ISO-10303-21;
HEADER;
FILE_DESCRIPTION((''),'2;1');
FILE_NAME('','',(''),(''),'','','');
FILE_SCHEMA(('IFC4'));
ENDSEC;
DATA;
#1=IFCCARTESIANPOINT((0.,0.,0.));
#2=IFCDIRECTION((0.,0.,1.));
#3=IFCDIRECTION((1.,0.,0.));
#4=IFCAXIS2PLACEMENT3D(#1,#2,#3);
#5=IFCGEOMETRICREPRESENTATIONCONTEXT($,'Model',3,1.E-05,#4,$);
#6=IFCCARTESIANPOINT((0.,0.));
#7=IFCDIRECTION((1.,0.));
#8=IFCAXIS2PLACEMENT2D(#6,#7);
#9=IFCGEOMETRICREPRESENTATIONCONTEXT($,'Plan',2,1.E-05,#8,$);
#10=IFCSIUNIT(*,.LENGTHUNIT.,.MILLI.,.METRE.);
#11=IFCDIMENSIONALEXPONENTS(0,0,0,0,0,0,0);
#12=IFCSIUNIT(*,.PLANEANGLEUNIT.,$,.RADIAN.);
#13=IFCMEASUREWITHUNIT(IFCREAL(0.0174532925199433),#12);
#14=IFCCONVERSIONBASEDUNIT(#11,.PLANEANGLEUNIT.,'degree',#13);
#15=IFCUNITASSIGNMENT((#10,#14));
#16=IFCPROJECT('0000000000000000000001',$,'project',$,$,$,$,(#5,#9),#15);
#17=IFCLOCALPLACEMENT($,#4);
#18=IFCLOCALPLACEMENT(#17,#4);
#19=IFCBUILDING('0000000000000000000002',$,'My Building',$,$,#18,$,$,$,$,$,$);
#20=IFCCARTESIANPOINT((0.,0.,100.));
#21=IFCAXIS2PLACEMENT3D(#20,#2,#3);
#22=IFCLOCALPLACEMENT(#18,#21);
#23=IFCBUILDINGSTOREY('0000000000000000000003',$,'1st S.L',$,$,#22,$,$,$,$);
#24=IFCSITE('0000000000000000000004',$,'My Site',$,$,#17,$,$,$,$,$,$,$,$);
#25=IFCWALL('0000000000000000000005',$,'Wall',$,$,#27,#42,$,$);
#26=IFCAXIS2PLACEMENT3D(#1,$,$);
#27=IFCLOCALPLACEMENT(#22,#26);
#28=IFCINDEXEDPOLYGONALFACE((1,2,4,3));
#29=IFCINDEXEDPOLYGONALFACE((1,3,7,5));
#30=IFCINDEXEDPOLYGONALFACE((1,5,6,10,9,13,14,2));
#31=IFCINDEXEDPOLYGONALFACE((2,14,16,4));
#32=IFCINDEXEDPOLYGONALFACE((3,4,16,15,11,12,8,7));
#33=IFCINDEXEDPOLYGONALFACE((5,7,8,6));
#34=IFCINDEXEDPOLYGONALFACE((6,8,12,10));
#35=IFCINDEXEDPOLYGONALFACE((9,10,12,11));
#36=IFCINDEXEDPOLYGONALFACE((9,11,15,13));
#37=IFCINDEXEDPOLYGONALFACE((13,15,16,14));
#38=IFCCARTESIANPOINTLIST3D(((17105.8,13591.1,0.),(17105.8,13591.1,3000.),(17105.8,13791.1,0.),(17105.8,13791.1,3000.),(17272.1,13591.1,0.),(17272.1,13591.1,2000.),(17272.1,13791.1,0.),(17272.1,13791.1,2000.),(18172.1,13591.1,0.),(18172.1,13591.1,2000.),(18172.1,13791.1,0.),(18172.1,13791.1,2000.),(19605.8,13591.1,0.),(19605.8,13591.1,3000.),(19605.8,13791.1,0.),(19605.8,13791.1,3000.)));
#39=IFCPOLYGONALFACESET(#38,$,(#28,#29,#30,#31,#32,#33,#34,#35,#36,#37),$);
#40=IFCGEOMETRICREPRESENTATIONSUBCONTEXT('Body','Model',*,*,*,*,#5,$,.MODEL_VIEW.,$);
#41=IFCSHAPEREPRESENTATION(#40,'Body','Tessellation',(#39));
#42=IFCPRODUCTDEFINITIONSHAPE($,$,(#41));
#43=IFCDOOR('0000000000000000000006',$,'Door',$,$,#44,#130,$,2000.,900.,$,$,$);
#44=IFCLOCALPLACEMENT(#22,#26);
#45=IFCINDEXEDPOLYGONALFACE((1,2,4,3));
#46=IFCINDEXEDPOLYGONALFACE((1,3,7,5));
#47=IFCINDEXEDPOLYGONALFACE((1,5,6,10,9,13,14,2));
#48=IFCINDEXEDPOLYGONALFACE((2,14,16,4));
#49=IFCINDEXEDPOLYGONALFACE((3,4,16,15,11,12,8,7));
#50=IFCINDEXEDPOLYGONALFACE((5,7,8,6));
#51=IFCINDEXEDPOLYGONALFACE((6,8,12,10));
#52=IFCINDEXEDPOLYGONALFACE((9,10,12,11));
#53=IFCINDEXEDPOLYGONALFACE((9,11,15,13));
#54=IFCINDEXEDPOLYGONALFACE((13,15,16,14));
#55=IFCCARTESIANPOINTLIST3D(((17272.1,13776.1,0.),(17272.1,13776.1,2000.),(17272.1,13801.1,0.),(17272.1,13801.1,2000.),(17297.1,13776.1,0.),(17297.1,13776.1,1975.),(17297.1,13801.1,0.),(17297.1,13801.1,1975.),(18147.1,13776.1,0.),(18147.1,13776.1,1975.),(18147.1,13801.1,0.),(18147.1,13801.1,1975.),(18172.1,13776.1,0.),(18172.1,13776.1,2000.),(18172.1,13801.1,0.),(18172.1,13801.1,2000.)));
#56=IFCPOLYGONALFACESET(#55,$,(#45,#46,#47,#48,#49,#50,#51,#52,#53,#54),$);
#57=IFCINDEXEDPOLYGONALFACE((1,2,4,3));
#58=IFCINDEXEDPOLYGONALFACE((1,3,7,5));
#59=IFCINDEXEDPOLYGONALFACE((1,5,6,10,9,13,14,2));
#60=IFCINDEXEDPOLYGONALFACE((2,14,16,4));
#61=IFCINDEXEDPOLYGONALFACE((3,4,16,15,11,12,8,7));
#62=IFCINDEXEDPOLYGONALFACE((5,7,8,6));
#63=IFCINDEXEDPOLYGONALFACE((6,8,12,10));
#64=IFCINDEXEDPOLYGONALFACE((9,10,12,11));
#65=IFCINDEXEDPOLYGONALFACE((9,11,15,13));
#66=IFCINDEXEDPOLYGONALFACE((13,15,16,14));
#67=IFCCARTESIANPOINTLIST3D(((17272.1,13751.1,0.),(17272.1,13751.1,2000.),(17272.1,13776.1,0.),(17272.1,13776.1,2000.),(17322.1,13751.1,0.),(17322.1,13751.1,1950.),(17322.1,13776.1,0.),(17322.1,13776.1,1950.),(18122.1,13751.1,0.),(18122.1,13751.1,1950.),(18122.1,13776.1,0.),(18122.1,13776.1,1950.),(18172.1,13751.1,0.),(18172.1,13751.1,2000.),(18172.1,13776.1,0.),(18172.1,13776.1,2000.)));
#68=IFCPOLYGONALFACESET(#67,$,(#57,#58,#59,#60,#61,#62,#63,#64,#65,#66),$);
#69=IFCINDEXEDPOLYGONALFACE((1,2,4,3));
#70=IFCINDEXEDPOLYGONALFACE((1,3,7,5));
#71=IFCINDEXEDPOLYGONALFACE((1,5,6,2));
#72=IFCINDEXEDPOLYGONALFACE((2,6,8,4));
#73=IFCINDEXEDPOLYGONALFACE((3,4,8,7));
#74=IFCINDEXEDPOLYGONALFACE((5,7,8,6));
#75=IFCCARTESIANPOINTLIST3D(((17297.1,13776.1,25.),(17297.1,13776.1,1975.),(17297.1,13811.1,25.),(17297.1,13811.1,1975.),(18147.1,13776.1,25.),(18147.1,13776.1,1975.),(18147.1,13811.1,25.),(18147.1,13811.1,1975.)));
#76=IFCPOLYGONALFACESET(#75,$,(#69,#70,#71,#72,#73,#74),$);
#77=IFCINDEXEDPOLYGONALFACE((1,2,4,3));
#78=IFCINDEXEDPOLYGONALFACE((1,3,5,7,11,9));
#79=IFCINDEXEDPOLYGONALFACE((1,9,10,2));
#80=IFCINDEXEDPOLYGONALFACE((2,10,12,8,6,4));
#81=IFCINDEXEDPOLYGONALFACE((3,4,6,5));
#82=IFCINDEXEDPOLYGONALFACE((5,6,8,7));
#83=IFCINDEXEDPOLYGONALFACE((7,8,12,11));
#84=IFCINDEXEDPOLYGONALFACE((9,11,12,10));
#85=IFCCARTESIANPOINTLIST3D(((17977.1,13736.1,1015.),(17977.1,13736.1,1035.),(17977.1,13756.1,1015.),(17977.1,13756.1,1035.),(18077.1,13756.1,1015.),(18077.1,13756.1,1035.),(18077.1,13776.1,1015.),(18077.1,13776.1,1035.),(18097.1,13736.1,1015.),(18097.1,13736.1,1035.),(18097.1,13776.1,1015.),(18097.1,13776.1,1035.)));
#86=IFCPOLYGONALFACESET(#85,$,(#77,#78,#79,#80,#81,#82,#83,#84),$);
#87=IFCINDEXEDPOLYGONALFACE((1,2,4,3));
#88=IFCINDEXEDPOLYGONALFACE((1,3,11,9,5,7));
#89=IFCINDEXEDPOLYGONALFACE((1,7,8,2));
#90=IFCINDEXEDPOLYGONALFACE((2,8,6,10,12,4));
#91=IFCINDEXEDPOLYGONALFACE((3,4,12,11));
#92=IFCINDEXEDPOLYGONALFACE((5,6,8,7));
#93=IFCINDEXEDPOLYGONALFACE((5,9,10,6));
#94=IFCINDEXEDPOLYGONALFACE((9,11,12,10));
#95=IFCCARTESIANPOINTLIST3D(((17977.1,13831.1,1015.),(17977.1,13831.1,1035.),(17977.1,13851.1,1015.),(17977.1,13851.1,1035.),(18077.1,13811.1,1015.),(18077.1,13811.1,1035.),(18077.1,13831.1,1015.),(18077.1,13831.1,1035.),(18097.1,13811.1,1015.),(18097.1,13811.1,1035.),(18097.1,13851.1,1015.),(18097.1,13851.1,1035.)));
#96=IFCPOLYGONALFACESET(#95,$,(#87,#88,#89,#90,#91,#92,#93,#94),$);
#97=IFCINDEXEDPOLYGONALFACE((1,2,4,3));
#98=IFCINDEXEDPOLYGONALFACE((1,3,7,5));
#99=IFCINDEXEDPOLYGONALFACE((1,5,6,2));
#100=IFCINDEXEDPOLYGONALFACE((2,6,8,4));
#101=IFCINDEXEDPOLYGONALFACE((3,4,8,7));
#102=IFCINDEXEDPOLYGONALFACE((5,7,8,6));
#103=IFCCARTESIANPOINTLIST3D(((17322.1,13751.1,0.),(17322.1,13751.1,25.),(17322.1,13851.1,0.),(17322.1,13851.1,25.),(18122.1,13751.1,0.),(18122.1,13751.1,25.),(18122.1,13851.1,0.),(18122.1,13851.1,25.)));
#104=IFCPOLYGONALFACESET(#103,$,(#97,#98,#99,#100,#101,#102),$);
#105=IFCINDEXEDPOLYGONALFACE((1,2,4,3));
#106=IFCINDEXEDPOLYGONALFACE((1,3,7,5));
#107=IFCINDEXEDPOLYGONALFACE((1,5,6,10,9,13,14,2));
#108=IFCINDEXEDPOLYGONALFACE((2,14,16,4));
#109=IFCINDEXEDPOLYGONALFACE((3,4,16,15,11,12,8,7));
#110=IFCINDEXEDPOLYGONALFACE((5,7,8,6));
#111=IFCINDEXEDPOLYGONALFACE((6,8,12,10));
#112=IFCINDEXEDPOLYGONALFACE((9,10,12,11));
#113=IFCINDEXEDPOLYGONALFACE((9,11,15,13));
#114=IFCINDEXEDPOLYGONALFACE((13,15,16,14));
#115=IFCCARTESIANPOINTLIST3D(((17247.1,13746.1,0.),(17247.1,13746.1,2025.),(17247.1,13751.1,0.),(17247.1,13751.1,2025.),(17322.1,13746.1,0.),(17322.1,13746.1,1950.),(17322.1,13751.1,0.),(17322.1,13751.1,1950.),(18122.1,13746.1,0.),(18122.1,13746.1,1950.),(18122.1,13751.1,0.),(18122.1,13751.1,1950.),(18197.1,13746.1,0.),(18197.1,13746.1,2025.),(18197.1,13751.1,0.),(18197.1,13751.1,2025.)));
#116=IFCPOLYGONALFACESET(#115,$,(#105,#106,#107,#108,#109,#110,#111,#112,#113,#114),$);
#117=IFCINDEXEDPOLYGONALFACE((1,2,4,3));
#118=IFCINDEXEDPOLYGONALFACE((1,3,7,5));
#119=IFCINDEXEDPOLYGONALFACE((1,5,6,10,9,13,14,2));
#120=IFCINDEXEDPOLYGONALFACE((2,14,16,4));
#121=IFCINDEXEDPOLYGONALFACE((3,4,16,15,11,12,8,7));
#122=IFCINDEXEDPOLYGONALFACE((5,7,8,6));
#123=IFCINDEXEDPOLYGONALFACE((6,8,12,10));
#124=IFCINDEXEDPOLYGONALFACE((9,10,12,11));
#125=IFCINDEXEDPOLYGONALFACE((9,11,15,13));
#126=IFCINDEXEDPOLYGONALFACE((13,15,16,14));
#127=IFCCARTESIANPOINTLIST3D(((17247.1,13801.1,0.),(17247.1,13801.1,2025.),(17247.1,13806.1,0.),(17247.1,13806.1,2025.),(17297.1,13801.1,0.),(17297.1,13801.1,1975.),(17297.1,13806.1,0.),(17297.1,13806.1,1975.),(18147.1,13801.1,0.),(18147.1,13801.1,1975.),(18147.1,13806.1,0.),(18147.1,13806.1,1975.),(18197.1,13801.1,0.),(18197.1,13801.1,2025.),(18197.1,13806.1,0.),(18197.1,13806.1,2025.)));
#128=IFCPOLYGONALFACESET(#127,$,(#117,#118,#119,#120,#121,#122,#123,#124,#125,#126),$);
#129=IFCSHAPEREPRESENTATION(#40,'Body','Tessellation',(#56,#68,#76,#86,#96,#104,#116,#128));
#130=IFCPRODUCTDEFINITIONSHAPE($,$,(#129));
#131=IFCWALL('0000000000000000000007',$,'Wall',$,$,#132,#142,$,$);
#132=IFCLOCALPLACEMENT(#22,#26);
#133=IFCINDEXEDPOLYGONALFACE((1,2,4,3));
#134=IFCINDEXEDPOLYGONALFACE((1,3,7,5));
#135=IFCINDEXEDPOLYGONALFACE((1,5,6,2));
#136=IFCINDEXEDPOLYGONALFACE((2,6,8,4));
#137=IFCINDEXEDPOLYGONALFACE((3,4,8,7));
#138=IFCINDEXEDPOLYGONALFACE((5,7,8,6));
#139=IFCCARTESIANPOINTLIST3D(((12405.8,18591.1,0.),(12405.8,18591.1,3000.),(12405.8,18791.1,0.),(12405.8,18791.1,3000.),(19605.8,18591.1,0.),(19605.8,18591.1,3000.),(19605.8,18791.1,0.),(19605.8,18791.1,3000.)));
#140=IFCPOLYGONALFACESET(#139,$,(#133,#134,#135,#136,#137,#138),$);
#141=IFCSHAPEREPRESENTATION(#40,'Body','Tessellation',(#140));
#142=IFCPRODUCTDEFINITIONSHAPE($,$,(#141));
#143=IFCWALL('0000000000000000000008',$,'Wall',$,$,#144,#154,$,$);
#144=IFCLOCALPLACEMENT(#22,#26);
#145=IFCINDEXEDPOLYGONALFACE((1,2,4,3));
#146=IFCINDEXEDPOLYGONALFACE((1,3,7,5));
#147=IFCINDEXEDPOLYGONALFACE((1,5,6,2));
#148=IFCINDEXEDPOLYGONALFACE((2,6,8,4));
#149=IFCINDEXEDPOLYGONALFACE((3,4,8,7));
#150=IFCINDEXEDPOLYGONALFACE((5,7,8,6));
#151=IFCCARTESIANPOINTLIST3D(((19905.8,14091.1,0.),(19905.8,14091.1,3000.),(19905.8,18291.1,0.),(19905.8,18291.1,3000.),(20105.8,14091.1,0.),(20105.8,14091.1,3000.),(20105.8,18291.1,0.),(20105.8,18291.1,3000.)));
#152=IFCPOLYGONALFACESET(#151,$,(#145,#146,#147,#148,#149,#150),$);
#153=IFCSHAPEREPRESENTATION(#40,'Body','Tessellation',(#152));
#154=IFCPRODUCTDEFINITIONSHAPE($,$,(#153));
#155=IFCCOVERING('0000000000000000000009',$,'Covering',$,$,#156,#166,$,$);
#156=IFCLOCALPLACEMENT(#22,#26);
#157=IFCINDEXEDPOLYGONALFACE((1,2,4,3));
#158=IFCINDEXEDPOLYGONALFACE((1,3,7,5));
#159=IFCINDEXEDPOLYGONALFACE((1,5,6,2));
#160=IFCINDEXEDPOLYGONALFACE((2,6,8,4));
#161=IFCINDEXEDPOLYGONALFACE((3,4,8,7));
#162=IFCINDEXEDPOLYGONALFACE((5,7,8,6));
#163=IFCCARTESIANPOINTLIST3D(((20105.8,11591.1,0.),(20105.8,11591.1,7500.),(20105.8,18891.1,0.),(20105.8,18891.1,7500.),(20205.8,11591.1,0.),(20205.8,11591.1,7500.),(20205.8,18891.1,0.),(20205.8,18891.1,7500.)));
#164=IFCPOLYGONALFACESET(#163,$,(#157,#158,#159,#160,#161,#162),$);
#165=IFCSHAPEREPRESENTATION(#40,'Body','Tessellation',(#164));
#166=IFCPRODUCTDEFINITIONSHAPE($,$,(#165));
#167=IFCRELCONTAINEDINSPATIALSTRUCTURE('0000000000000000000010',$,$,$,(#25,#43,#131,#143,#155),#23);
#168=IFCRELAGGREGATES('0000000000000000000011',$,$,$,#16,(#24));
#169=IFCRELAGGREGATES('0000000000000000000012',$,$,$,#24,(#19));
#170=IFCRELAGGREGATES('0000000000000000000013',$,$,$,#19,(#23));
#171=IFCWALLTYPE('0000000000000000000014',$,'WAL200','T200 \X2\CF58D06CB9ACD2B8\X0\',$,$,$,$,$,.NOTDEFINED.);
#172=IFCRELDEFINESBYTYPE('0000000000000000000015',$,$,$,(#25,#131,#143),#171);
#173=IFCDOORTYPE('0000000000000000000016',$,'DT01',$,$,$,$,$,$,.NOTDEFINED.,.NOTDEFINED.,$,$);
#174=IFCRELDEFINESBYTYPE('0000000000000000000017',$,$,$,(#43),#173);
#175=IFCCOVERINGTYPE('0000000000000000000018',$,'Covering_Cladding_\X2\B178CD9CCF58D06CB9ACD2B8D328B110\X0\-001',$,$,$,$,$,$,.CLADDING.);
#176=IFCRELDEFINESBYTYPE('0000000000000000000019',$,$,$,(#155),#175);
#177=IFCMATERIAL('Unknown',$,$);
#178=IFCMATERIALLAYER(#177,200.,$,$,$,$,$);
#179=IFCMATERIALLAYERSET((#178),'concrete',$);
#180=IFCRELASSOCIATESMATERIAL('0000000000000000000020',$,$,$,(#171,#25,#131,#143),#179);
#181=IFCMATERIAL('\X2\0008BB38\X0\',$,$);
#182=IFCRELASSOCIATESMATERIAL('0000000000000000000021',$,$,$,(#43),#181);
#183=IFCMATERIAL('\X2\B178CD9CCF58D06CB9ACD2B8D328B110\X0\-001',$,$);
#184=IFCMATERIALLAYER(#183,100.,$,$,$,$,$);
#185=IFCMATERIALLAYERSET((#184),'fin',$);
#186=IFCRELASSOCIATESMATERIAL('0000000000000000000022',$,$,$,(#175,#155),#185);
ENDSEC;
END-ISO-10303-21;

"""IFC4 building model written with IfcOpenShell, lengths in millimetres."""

from ifc_helpers import new_model, entity, si_unit, converted_unit, frame, origin_with_axes, origin_2d_with_axis, place, context, subcontext, project, spatial, line, indexed_curve, outline, extrude, shape, source, transform, mapped, material, layer, layer_set, layer_usage, type_object, type_shapes, element, fill, save


model = new_model("IFC4")

# Units and contexts
model_context = context("Model", 3, precision=1e-05, world=origin_with_axes())
plan_context = context("Plan", 2, precision=1e-05, world=origin_2d_with_axis())
body_context_1 = subcontext(model_context, "Body", "Model", "MODEL_VIEW")
body_context_2 = subcontext(plan_context, "Body", "Plan", "PLAN_VIEW")
ifc_project = project(units=[si_unit("LENGTHUNIT", "METRE", prefix="MILLI"), converted_unit("PLANEANGLEUNIT", "degree", entity("IfcReal", 0.0174532925199433), si_unit("PLANEANGLEUNIT", "RADIAN"), dimensions=[0, 0, 0, 0, 0, 0, 0])], contexts=[model_context, plan_context])

# Site, building, storey
site_placement = place(None, origin_with_axes())
site = spatial("IfcSite", under=ifc_project, at=site_placement, Name="My Site")
building_placement = place(site_placement, origin_with_axes())
building = spatial("IfcBuilding", under=site, at=building_placement, Name="My Building")
storey_placement = place(building_placement, frame((0.0, 0.0, 100.0), z_axis=(0.0, 0.0, 1.0), x_axis=(1.0, 0.0, 0.0)))
storey = spatial("IfcBuildingStorey", under=building, at=storey_placement, Name="1st S.L")

# Shared definitions
ifc_material_1 = material(Name="Unknown")

# Shared definitions
ifc_layer_1 = layer(ifc_material_1, 200.0)
ifc_layer_set_1 = layer_set([ifc_layer_1], Name="concrete")
wall_type = type_object("IfcWallType", Name="WAL200", Description="T200 콘크리트", PredefinedType="NOTDEFINED", material=ifc_layer_set_1)

# Wall, opening, door
ifc_layer_usage_1 = layer_usage(ifc_layer_set_1, "AXIS2", "POSITIVE", 0.0)
wall_1_placement = place(storey_placement, frame((17105.8, 13591.1, 0.0), z_axis=(0.0, 0.0, 1.0), x_axis=(1.0, 0.0, 0.0)))
wall_1 = element("IfcWall", 1, at=wall_1_placement, inside=storey, type_object=wall_type, material=ifc_layer_usage_1, Name="Wall", context=body_context_1, shape_type="SweptSolid", body=[
    extrude(outline(indexed_curve([(0.0, 0.0), (0.0, 200.0), (2500.0, 200.0), (2500.0, 0.0), (0.0, 0.0)], self_intersect=False)), origin_with_axes(), (0.0, 0.0, 1.0), 3000.0),
])
shared_shape_1 = source(origin_with_axes(), body_context_1, "Body", "SolidModel", [
    extrude(outline(indexed_curve([(0.0, 0.0), (900.0, 0.0), (900.0, 2000.0), (0.0, 2000.0)], segments=[line(1, 2, 3, 4, 1)])), frame((0.0, -600.0, 0.0), z_axis=(0.0, -1.0, 0.0), x_axis=(1.0, 0.0, 0.0)), (0.0, 0.0, -1.0), 1200.0),
])
opening_placement = place(wall_1_placement, frame((166.3, 0.0, 0.0), z_axis=(0.0, 0.0, 1.0), x_axis=(1.0, 0.0, 0.0)))
opening = element("IfcOpeningElement", 2, at=opening_placement, cuts=wall_1, PredefinedType="OPENING", context=body_context_1, shape_type="MappedRepresentation", body=[
    mapped(shared_shape_1, transform((0.0, 0.0, 0.0), x_axis=(1.0, 0.0, 0.0), y_axis=(0.0, 1.0, 0.0), z_axis=(0.0, 0.0, 1.0), scale=1.0)),
])
ifc_material_2 = material(Name="\b문")
door_type = type_object("IfcDoorType", Name="DT01", OperationType="NOTDEFINED", PredefinedType="NOTDEFINED")
shared_shape_2 = source(origin_with_axes(), body_context_1, "Body", "SolidModel", [
    extrude(outline(indexed_curve([(0.0, 0.0), (0.0, 2000.0), (900.0, 2000.0), (900.0, 0.0), (875.0, 0.0), (875.0, 1975.0), (25.0, 1975.0), (25.0, 0.0)], segments=[line(1, 2, 3, 4, 5, 6, 7, 8, 1)])), frame((0.0, 25.0, 0.0), z_axis=(0.0, -1.0, 0.0), x_axis=(1.0, 0.0, 0.0)), (0.0, 0.0, -1.0), 25.0),
    extrude(outline(indexed_curve([(0.0, 0.0), (0.0, 2000.0), (900.0, 2000.0), (900.0, 0.0), (850.0, 0.0), (850.0, 1950.0), (50.0, 1950.0), (50.0, 0.0)], segments=[line(1, 2, 3, 4, 5, 6, 7, 8, 1)])), frame((0.0, 0.0, 0.0), z_axis=(0.0, -1.0, 0.0), x_axis=(1.0, 0.0, 0.0)), (0.0, 0.0, -1.0), 25.0),
    extrude(outline(indexed_curve([(0.0, 0.0), (850.0, 0.0), (850.0, 35.0), (0.0, 35.0)], segments=[line(1, 2, 3, 4, 1)])), frame((25.0, 25.0, 25.0), z_axis=(0.0, 0.0, 1.0), x_axis=(1.0, 0.0, 0.0)), (0.0, 0.0, 1.0), 1950.0),
    extrude(outline(indexed_curve([(0.0, 0.0), (0.0, -40.0), (-120.0, -40.0), (-120.0, -20.0), (-20.0, -20.0), (-20.0, 0.0)], segments=[line(1, 2, 3, 4, 5, 6, 1)])), frame((825.0, 25.0, 1015.0), z_axis=(0.0, 0.0, 1.0), x_axis=(1.0, 0.0, 0.0)), (0.0, 0.0, 1.0), 20.0),
    extrude(outline(indexed_curve([(0.0, 0.0), (0.0, 40.0), (-120.0, 40.0), (-120.0, 20.0), (-20.0, 20.0), (-20.0, 0.0)], segments=[line(1, 2, 3, 4, 5, 6, 1)])), frame((825.0, 60.0, 1015.0), z_axis=(0.0, 0.0, 1.0), x_axis=(1.0, 0.0, 0.0)), (0.0, 0.0, 1.0), 20.0),
    extrude(outline(indexed_curve([(0.0, 0.0), (800.0, 0.0), (800.0, 100.0), (0.0, 100.0)], segments=[line(1, 2, 3, 4, 1)])), frame((50.0, 0.0, 0.0), z_axis=(0.0, 0.0, 1.0), x_axis=(1.0, 0.0, 0.0)), (0.0, 0.0, 1.0), 25.0),
    extrude(outline(indexed_curve([(0.0, 0.0), (0.0, 2025.0), (950.0, 2025.0), (950.0, 0.0), (875.0, 0.0), (875.0, 1950.0), (75.0, 1950.0), (75.0, 0.0)], segments=[line(1, 2, 3, 4, 5, 6, 7, 8, 1)])), frame((-25.0, -5.0, 0.0), z_axis=(0.0, -1.0, 0.0), x_axis=(1.0, 0.0, 0.0)), (0.0, 0.0, -1.0), 5.0),
    extrude(outline(indexed_curve([(0.0, 0.0), (0.0, 2025.0), (950.0, 2025.0), (950.0, 0.0), (900.0, 0.0), (900.0, 1975.0), (50.0, 1975.0), (50.0, 0.0)], segments=[line(1, 2, 3, 4, 5, 6, 7, 8, 1)])), frame((-25.0, 50.0, 0.0), z_axis=(0.0, -1.0, 0.0), x_axis=(1.0, 0.0, 0.0)), (0.0, 0.0, -1.0), 5.0),
])
shared_shape_3 = source(origin_with_axes(), body_context_2, "Body", "Curve2D", [
    entity("IfcIndexedPolyCurve", entity("IfcCartesianPointList2D", [[0.0, 0.0], [0.0, 50.0], [25.0, 50.0], [25.0, 25.0], [50.0, 25.0], [50.0, 0.0]]), [entity("IfcLineIndex", [1, 2, 3, 4, 5, 6, 1])]),
    entity("IfcIndexedPolyCurve", entity("IfcCartesianPointList2D", [[900.0, 0.0], [900.0, 50.0], [875.0, 50.0], [875.0, 25.0], [850.0, 25.0], [850.0, 0.0]]), [entity("IfcLineIndex", [1, 2, 3, 4, 5, 6, 1])]),
    entity("IfcTrimmedCurve", entity("IfcEllipse", entity("IfcAxis2Placement2D", entity("IfcCartesianPoint", [60.0, 50.0]), entity("IfcDirection", [1.0, 0.0])), 815.0, 850.0), [entity("IfcCartesianPoint", [875.0, 50.0])], [entity("IfcCartesianPoint", [60.0, 900.0])], True, "CARTESIAN"),
    entity("IfcIndexedPolyCurve", entity("IfcCartesianPointList2D", [[25.0, 50.0], [60.0, 50.0], [60.0, 900.0], [25.0, 900.0]]), [entity("IfcLineIndex", [1, 2, 3, 4, 1])]),
])
type_shapes(door_type, [shared_shape_2, shared_shape_3])
door_placement = place(opening_placement, frame((0.0, 160.0, 0.0), z_axis=(0.0, 0.0, 1.0), x_axis=(1.0, 0.0, 0.0)))
door = element("IfcDoor", 3, at=door_placement, inside=storey, type_object=door_type, material=ifc_material_2, Name="Door", OverallHeight=2000.0, OverallWidth=900.0, shapes=[
    shape(body_context_1, "Body", "MappedRepresentation", [mapped(shared_shape_2, transform((0.0, 0.0, 0.0), x_axis=(1.0, 0.0, 0.0), y_axis=(0.0, 1.0, 0.0), z_axis=(0.0, 0.0, 1.0), scale=1.0))]),
    shape(body_context_2, "Body", "MappedRepresentation", [mapped(shared_shape_3, transform((0.0, 0.0, 0.0), x_axis=(1.0, 0.0, 0.0), y_axis=(0.0, 1.0, 0.0), z_axis=(0.0, 0.0, 1.0), scale=1.0))]),
])
fill(opening, door)

# Walls
ifc_layer_usage_2 = layer_usage(ifc_layer_set_1, "AXIS2", "POSITIVE", 0.0)
wall_2_placement = place(storey_placement, frame((12405.8, 18591.1, 0.0), z_axis=(0.0, 0.0, 1.0), x_axis=(1.0, 0.0, 0.0)))
element("IfcWall", 4, at=wall_2_placement, inside=storey, type_object=wall_type, material=ifc_layer_usage_2, Name="Wall", context=body_context_1, shape_type="SweptSolid", body=[
    extrude(outline(indexed_curve([(0.0, 0.0), (0.0, 200.0), (7200.0, 200.0), (7200.0, 0.0), (0.0, 0.0)], self_intersect=False)), origin_with_axes(), (0.0, 0.0, 1.0), 3000.0),
])
ifc_layer_usage_3 = layer_usage(ifc_layer_set_1, "AXIS2", "POSITIVE", 0.0)
wall_3_placement = place(storey_placement, frame((20105.8, 14091.1, 0.0), z_axis=(0.0, 0.0, 1.0), x_axis=(0.0, 1.0, 0.0)))
element("IfcWall", 5, at=wall_3_placement, inside=storey, type_object=wall_type, material=ifc_layer_usage_3, Name="Wall", context=body_context_1, shape_type="SweptSolid", body=[
    extrude(outline(indexed_curve([(0.0, 0.0), (0.0, 200.0), (4200.0, 200.0), (4200.0, 0.0), (0.0, 0.0)], self_intersect=False)), origin_with_axes(), (0.0, 0.0, 1.0), 3000.0),
])

# Covering
ifc_material_3 = material(Name="노출콘크리트패널-001")
ifc_layer_2 = layer(ifc_material_3, 100.0)
ifc_layer_set_2 = layer_set([ifc_layer_2], Name="fin")
ifc_layer_usage_4 = layer_usage(ifc_layer_set_2, "AXIS2", "POSITIVE", 0.0)
covering_type = type_object("IfcCoveringType", Name="Covering_Cladding_노출콘크리트패널-001", PredefinedType="CLADDING", material=ifc_layer_set_2)
covering_1_placement = place(storey_placement, frame((20105.8, 18891.1, 0.0), z_axis=(0.0, 0.0, 1.0), x_axis=(-0.000001, -1.0, 0.0)))
element("IfcCovering", 6, at=covering_1_placement, inside=storey, type_object=covering_type, material=ifc_layer_usage_4, Name="Covering", context=body_context_1, shape_type="SweptSolid", body=[
    extrude(outline(indexed_curve([(0.0, 0.0), (0.0, 100.0), (7300.0, 100.0), (7300.0, 0.0), (0.0, 0.0)], self_intersect=False)), origin_with_axes(), (0.0, 0.0, 1.0), 7500.0),
])

save(model, "model.ifc")
